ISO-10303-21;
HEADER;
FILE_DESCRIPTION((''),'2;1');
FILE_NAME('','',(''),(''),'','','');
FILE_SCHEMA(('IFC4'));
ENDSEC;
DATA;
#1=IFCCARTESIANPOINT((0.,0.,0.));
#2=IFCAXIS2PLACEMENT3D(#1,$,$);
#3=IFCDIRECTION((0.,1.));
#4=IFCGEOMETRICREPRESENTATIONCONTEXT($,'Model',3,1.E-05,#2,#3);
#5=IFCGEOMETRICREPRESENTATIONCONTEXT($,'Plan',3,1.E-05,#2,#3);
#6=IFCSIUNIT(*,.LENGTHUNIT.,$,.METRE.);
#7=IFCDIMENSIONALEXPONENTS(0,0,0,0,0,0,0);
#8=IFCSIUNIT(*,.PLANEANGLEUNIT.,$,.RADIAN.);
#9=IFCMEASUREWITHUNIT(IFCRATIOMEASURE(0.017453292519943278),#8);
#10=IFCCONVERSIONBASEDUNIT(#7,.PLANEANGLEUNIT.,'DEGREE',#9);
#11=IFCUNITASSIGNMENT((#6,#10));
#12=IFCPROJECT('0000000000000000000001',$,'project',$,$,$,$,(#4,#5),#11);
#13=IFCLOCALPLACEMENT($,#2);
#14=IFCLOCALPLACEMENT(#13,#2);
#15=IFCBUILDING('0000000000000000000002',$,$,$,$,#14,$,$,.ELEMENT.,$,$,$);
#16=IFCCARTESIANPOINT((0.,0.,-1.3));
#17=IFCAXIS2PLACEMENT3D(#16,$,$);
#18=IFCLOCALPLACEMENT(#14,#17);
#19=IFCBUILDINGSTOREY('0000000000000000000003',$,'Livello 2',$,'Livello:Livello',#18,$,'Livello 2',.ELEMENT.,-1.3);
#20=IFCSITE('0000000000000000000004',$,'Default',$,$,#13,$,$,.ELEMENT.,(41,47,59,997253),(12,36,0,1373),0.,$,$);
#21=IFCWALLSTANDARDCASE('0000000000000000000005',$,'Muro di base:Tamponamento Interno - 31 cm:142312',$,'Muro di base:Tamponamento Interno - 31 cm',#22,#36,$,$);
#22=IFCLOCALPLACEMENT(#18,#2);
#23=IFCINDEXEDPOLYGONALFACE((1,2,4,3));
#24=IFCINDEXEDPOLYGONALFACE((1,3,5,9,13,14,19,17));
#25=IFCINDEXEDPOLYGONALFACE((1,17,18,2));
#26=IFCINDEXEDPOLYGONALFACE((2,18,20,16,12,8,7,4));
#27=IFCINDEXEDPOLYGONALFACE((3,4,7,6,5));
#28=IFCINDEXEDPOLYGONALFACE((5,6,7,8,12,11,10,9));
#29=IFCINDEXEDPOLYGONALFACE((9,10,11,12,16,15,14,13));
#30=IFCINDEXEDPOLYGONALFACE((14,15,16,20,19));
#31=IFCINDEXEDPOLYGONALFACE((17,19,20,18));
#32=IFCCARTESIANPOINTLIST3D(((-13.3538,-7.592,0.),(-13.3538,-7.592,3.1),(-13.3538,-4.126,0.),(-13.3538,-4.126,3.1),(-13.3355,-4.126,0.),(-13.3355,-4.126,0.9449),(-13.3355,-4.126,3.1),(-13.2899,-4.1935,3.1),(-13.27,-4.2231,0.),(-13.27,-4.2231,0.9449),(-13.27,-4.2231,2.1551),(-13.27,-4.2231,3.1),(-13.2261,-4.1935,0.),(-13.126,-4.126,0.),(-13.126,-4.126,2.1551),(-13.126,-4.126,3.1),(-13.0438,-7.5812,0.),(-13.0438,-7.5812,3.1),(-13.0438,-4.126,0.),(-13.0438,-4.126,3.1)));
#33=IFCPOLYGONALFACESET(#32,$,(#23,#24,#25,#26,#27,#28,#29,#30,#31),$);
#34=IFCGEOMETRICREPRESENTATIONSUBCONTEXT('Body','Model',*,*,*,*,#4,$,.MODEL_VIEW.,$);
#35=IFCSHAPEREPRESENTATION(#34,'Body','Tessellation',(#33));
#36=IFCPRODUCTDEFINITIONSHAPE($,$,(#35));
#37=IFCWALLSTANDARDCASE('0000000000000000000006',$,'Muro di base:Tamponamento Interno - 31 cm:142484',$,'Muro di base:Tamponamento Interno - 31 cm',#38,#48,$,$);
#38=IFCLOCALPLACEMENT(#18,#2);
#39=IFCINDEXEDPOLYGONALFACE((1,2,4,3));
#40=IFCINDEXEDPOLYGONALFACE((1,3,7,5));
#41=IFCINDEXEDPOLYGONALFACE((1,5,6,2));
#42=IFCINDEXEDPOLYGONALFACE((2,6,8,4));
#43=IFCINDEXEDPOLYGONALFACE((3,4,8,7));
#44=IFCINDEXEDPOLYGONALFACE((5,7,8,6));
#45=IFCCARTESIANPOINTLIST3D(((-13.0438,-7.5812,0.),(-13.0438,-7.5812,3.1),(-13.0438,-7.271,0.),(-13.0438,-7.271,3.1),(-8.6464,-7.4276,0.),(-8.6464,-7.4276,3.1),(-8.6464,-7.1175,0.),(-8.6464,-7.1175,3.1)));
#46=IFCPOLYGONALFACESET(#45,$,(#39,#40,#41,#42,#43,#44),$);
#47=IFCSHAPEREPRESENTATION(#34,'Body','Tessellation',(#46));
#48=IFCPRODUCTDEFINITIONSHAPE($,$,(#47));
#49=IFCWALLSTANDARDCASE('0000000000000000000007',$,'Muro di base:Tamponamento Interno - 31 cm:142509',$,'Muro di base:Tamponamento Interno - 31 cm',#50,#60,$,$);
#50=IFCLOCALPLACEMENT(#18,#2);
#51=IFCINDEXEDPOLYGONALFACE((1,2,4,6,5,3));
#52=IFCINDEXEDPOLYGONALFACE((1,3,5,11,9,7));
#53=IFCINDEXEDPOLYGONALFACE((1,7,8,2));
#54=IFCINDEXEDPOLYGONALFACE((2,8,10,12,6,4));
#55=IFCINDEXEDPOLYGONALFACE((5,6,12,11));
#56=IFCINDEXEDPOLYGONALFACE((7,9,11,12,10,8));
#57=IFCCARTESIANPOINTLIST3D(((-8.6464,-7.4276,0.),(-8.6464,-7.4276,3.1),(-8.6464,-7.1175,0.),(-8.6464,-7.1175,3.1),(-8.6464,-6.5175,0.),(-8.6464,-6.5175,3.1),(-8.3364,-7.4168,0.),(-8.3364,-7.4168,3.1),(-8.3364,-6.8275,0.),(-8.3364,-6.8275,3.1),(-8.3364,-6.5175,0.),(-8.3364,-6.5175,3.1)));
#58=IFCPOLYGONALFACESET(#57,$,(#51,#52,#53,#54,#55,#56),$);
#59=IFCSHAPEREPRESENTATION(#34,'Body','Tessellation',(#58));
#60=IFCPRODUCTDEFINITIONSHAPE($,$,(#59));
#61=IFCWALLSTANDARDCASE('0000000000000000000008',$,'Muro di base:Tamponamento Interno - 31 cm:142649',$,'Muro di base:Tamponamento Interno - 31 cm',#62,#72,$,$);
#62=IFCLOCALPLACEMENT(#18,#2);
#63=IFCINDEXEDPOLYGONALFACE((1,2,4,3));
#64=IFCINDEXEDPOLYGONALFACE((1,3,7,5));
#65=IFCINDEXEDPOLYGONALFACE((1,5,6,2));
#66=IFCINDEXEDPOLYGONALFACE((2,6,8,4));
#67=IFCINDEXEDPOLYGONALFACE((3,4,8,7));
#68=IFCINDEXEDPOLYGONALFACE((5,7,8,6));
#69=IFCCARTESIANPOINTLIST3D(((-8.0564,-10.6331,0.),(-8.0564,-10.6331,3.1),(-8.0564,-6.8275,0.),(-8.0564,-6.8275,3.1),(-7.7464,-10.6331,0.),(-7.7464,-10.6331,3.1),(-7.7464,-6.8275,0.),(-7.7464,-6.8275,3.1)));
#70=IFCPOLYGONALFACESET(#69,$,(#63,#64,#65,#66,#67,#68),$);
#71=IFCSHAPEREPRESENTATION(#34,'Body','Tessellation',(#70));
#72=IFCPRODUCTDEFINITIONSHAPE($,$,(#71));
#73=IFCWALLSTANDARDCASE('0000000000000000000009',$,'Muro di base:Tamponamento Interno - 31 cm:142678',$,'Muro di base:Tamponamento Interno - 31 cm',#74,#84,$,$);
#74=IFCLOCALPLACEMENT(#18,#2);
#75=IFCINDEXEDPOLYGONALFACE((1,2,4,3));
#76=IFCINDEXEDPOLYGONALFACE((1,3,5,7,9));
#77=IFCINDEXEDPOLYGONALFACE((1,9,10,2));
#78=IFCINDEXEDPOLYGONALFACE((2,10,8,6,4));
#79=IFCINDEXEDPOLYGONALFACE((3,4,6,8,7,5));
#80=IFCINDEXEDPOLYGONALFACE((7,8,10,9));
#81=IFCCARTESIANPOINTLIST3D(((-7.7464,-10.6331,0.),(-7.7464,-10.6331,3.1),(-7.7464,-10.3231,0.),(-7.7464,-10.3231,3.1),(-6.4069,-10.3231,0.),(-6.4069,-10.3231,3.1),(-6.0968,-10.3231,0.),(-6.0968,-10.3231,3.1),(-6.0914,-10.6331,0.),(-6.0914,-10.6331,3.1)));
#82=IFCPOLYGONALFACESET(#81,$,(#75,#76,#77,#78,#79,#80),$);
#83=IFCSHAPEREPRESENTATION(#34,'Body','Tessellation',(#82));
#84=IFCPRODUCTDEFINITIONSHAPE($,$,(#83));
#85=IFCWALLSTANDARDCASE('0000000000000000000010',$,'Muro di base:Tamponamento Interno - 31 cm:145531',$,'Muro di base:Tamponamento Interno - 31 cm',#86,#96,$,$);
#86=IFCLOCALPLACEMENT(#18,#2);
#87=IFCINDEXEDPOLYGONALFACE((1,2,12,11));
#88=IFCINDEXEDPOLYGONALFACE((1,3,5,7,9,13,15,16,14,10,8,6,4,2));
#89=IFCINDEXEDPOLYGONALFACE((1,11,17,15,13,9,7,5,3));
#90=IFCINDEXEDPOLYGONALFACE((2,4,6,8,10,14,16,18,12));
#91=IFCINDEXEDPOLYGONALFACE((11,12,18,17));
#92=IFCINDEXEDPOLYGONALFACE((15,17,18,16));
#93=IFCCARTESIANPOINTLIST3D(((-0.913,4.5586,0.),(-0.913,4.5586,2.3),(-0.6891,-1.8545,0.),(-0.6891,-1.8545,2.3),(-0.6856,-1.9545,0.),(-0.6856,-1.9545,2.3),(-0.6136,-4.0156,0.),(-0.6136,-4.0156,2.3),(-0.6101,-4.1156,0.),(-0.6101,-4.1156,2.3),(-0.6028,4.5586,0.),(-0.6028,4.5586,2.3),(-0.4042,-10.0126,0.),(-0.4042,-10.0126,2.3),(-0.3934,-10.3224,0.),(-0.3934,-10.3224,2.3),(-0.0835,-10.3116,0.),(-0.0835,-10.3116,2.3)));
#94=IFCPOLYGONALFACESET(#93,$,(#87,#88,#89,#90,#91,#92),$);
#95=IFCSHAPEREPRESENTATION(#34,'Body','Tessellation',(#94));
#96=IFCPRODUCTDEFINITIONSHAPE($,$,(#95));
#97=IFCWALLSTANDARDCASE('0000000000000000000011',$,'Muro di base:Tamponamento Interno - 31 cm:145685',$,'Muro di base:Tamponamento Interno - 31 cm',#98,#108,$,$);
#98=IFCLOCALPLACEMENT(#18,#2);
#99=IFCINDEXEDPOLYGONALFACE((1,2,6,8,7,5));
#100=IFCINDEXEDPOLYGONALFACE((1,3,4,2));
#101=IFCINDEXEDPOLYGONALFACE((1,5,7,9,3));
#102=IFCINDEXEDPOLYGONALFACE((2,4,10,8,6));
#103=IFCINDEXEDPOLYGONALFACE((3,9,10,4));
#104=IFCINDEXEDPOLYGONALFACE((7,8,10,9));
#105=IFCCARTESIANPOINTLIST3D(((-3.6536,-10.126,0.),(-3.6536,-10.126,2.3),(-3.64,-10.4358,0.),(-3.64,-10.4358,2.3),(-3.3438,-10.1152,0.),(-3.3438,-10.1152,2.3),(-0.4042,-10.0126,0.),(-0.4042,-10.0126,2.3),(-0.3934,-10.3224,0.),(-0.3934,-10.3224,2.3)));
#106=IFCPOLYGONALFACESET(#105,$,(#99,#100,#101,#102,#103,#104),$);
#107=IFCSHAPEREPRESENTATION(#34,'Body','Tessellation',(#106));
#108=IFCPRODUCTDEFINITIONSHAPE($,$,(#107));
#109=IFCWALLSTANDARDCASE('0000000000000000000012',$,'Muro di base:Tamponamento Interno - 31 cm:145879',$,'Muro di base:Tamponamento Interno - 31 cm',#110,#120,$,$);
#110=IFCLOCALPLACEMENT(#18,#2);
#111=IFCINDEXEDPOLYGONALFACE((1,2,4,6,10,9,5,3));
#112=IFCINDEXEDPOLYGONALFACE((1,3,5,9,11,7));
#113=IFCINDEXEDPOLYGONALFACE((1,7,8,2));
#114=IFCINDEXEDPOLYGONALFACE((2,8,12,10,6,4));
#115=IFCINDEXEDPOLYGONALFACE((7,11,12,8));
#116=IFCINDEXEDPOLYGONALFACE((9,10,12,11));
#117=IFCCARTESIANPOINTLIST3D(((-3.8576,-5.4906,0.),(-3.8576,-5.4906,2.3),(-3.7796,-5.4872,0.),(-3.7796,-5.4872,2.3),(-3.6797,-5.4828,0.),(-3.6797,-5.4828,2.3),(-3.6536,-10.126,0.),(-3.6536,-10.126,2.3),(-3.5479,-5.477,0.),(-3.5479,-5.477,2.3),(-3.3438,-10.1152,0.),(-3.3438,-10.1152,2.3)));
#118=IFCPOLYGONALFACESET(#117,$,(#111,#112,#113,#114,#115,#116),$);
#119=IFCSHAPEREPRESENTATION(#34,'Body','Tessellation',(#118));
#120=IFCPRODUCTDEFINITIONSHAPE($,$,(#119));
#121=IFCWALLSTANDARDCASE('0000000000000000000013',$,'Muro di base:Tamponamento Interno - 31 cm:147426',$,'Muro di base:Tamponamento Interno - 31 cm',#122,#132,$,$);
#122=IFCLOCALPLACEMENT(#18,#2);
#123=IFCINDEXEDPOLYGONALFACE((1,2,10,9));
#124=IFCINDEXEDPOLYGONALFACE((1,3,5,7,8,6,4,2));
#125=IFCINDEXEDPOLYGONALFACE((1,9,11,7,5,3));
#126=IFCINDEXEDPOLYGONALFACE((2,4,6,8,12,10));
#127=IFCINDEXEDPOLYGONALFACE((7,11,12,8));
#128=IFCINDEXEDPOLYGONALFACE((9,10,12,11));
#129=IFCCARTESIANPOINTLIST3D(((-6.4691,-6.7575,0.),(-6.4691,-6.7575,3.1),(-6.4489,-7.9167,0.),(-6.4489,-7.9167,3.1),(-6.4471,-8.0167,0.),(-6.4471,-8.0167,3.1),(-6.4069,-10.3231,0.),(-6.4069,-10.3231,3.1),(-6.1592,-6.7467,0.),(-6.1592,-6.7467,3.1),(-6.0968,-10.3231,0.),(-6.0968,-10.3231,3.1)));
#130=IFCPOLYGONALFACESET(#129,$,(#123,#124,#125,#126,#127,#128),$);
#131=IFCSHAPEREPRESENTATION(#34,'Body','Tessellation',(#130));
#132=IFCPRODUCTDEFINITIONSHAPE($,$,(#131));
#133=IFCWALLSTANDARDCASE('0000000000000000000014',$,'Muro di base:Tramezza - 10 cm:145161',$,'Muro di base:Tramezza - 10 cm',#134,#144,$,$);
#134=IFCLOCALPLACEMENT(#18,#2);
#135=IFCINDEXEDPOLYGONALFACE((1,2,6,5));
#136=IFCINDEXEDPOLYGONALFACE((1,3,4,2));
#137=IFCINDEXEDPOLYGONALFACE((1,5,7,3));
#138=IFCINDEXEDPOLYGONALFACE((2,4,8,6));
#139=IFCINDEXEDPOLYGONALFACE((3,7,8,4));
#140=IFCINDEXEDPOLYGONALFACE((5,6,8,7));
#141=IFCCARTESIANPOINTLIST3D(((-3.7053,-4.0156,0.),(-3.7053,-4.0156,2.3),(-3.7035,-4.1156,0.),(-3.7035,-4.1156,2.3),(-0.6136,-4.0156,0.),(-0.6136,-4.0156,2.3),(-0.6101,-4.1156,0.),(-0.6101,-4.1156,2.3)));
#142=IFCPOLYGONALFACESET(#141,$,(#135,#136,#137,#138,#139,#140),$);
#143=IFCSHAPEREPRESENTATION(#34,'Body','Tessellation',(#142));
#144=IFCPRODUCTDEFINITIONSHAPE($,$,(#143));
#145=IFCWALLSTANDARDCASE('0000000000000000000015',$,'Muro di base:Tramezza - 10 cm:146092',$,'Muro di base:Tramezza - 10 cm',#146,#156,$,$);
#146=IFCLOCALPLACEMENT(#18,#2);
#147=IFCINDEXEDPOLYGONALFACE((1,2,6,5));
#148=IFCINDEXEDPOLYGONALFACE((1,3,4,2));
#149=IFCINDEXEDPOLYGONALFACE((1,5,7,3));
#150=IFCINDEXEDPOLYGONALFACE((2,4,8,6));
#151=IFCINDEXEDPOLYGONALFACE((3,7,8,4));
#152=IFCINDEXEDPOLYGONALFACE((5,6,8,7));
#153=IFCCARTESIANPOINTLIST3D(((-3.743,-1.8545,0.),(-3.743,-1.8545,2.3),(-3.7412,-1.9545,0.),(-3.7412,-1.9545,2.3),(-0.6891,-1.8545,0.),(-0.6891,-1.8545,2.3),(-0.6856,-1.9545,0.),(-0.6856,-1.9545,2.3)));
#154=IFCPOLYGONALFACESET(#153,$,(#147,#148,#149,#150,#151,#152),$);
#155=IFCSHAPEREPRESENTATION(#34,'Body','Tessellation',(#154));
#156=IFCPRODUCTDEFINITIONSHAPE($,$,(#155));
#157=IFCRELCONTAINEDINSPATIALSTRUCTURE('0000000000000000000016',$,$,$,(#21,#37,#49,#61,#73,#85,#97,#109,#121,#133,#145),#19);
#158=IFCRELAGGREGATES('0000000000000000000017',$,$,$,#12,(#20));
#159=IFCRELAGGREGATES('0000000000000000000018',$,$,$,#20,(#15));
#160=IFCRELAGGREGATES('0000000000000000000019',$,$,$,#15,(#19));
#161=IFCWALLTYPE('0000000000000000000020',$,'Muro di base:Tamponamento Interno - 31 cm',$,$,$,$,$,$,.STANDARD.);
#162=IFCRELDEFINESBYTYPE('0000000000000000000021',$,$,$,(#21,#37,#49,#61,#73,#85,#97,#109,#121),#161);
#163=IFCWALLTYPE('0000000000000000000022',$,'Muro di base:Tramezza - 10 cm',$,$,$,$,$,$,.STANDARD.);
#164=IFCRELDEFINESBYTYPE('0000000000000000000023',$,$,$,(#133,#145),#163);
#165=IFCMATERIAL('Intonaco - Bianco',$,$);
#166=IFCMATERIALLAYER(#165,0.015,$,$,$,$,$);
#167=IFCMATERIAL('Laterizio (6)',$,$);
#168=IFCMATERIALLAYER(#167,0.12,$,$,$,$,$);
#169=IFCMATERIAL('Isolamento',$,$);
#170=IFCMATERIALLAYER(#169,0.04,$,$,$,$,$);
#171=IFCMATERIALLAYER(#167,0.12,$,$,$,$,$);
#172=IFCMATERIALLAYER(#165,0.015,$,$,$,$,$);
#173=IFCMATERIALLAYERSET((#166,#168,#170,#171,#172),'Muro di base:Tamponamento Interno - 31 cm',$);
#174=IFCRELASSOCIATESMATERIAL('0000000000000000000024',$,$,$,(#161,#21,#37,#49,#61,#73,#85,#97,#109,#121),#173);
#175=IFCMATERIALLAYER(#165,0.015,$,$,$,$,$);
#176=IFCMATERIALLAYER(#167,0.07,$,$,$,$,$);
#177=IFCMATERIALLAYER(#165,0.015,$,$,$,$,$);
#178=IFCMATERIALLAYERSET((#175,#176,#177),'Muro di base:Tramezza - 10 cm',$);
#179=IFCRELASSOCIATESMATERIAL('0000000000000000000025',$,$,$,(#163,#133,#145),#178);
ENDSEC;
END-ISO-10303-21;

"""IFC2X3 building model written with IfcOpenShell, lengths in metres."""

from ifc_helpers import new_model, entity, si_unit, converted_unit, direction, frame, frame_2d, origin, place, context, subcontext, project, spatial, polyline, rectangle, outline, extrude, clip, bounded_halfspace, material, layer, layer_set, layer_usage, type_object, element, save


model = new_model("IFC2X3")

# Units and contexts
model_context = context("Model", 3, precision=1e-05, world=origin(), true_north=direction((0.0, 1.0)))
plan_context = context("Plan", 3, precision=1e-05, world=origin(), true_north=direction((0.0, 1.0)))
body_context = subcontext(model_context, "Body", "Model", "MODEL_VIEW")
ifc_project = project(units=[si_unit("LENGTHUNIT", "METRE"), converted_unit("PLANEANGLEUNIT", "DEGREE", entity("IfcRatioMeasure", 0.017453292519943278), si_unit("PLANEANGLEUNIT", "RADIAN"), dimensions=[0, 0, 0, 0, 0, 0, 0])], contexts=[model_context, plan_context])

# Site, building, storey
site_placement = place(None, origin())
site = spatial("IfcSite", under=ifc_project, at=site_placement, Name="Default", CompositionType="ELEMENT", RefLatitude=(41, 47, 59, 997253), RefLongitude=(12, 36, 0, 1373), RefElevation=0.0)
building_placement = place(site_placement, origin())
building = spatial("IfcBuilding", under=site, at=building_placement, CompositionType="ELEMENT")
storey_placement = place(building_placement, frame((0.0, 0.0, -1.3)))
storey = spatial("IfcBuildingStorey", under=building, at=storey_placement, Name="Livello 2", ObjectType="Livello:Livello", LongName="Livello 2", CompositionType="ELEMENT", Elevation=-1.3)

# Shared definitions
ifc_material_1 = material(Name="Intonaco - Bianco")

# Shared definitions
ifc_layer_1 = layer(ifc_material_1, 0.015)
ifc_material_2 = material(Name="Laterizio (6)")
ifc_layer_2 = layer(ifc_material_2, 0.12)
ifc_material_3 = material(Name="Isolamento")
ifc_layer_3 = layer(ifc_material_3, 0.04)
ifc_layer_4 = layer(ifc_material_2, 0.12)
ifc_layer_5 = layer(ifc_material_1, 0.015)
ifc_layer_set_1 = layer_set([ifc_layer_1, ifc_layer_2, ifc_layer_3, ifc_layer_4, ifc_layer_5], Name="Muro di base:Tamponamento Interno - 31 cm")
wall_type_1 = type_object("IfcWallType", Name="Muro di base:Tamponamento Interno - 31 cm", PredefinedType="STANDARD", material=ifc_layer_set_1)

# Walls
ifc_layer_usage_1 = layer_usage(ifc_layer_set_1, "AXIS2", "NEGATIVE", 0.155)
wall_1_placement = place(storey_placement, frame((-13.1988, -4.126, 0.0), z_axis=(0.0, 0.0, 1.0), x_axis=(0.0, -1.0, 0.0)))
element("IfcWallStandardCase", 1, at=wall_1_placement, inside=storey, type_object=wall_type_1, material=ifc_layer_usage_1, Name="Muro di base:Tamponamento Interno - 31 cm:142312", ObjectType="Muro di base:Tamponamento Interno - 31 cm", context=body_context, shape_type="Clipping", body=[
    clip(clip(extrude(outline(polyline([(3.466, -0.155), (3.4552, 0.155), (3.145, 0.155), (0.0, 0.155), (0.0, 0.0728), (0.0971, -0.0712), (0.0, -0.1367), (0.0, -0.155), (3.466, -0.155)])), origin(), (0.0, 0.0, 1.0), 3.1), bounded_halfspace(frame((0.0971, -0.0712, 3.1), z_axis=(0.559193, -0.829038, 0.0), x_axis=(0.0, 0.0, -1.0)), True, frame((0.0971, -0.0712, 3.1), z_axis=(0.559193, -0.829038, 0.0), x_axis=(0.0, 0.0, -1.0)), polyline([(0.0, 0.0), (0.0, -0.0357), (0.9449, -0.0357), (0.9449, 0.0), (0.0, 0.0)]))), bounded_halfspace(frame((0.0971, -0.0712, 0.0), z_axis=(0.829038, 0.559193, 0.0), x_axis=(0.0, 0.0, -1.0)), True, frame((0.0971, -0.0712, 0.0), z_axis=(0.829038, 0.559193, 0.0), x_axis=(0.0, 0.0, -1.0)), polyline([(0.0, 0.0), (0.0, 0.0529), (-0.9449, 0.0529), (-0.9449, 0.0), (0.0, 0.0)]))),
])
ifc_layer_usage_2 = layer_usage(ifc_layer_set_1, "AXIS2", "NEGATIVE", 0.155)
wall_2_placement = place(storey_placement, frame((-13.0492, -7.4263, 0.0), z_axis=(0.0, 0.0, 1.0), x_axis=(0.999391, 0.034899, 0.0)))
element("IfcWallStandardCase", 2, at=wall_2_placement, inside=storey, type_object=wall_type_1, material=ifc_layer_usage_2, Name="Muro di base:Tamponamento Interno - 31 cm:142484", ObjectType="Muro di base:Tamponamento Interno - 31 cm", context=body_context, shape_type="SweptSolid", body=[
    extrude(outline(polyline([(4.4, -0.155), (4.4108, 0.155), (0.0108, 0.155), (0.0, -0.155), (4.4, -0.155)])), origin(), (0.0, 0.0, 1.0), 3.1),
])
ifc_layer_usage_3 = layer_usage(ifc_layer_set_1, "AXIS2", "NEGATIVE", 0.155)
wall_3_placement = place(storey_placement, frame((-8.4914, -7.4276, 0.0), z_axis=(0.0, 0.0, 1.0), x_axis=(0.0, 1.0, 0.0)))
element("IfcWallStandardCase", 3, at=wall_3_placement, inside=storey, type_object=wall_type_1, material=ifc_layer_usage_3, Name="Muro di base:Tamponamento Interno - 31 cm:142509", ObjectType="Muro di base:Tamponamento Interno - 31 cm", context=body_context, shape_type="SweptSolid", body=[
    extrude(outline(polyline([(0.9102, -0.155), (0.9102, 0.155), (0.3102, 0.155), (0.0, 0.155), (0.0108, -0.155), (0.6002, -0.155), (0.9102, -0.155)])), origin(), (0.0, 0.0, 1.0), 3.1),
])
ifc_layer_usage_4 = layer_usage(ifc_layer_set_1, "AXIS2", "NEGATIVE", 0.155)
wall_4_placement = place(storey_placement, frame((-7.9014, -6.8275, 0.0), z_axis=(0.0, 0.0, 1.0), x_axis=(0.0, -1.0, 0.0)))
element("IfcWallStandardCase", 4, at=wall_4_placement, inside=storey, type_object=wall_type_1, material=ifc_layer_usage_4, Name="Muro di base:Tamponamento Interno - 31 cm:142649", ObjectType="Muro di base:Tamponamento Interno - 31 cm", context=body_context, shape_type="SweptSolid", body=[
    extrude(rectangle(XDim=3.8056, YDim=0.31, at=frame_2d((1.9028, 0.0), x_axis=(-1.0, 0.0))), origin(), (0.0, 0.0, 1.0), 3.1),
])
ifc_layer_usage_5 = layer_usage(ifc_layer_set_1, "AXIS2", "NEGATIVE", 0.155)
wall_5_placement = place(storey_placement, frame((-7.7464, -10.4781, 0.0)))
element("IfcWallStandardCase", 5, at=wall_5_placement, inside=storey, type_object=wall_type_1, material=ifc_layer_usage_5, Name="Muro di base:Tamponamento Interno - 31 cm:142678", ObjectType="Muro di base:Tamponamento Interno - 31 cm", context=body_context, shape_type="SweptSolid", body=[
    extrude(outline(polyline([(1.655, -0.155), (1.6496, 0.155), (1.3396, 0.155), (0.0, 0.155), (0.0, -0.155), (1.655, -0.155)])), origin(), (0.0, 0.0, 1.0), 3.1),
])
ifc_layer_usage_6 = layer_usage(ifc_layer_set_1, "AXIS2", "POSITIVE", -0.155)
wall_6_placement = place(storey_placement, frame((-0.7581, 4.564, 0.0), z_axis=(0.0, 0.0, 1.0), x_axis=(0.034899, -0.999391, 0.0)))
element("IfcWallStandardCase", 6, at=wall_6_placement, inside=storey, type_object=wall_type_1, material=ifc_layer_usage_6, Name="Muro di base:Tamponamento Interno - 31 cm:145531", ObjectType="Muro di base:Tamponamento Interno - 31 cm", context=body_context, shape_type="SweptSolid", body=[
    extrude(outline(polyline([(14.89, -0.155), (14.89, 0.155), (0.0108, 0.155), (0.0, -0.155), (6.4169, -0.155), (6.517, -0.155), (8.5794, -0.155), (8.6794, -0.155), (14.58, -0.155), (14.89, -0.155)])), origin(), (0.0, 0.0, 1.0), 2.3),
])
ifc_layer_usage_7 = layer_usage(ifc_layer_set_1, "AXIS2", "POSITIVE", -0.155)
wall_7_placement = place(storey_placement, frame((-0.3988, -10.1675, 0.0), z_axis=(0.0, 0.0, 1.0), x_axis=(-0.999391, -0.034899, 0.0)))
element("IfcWallStandardCase", 7, at=wall_7_placement, inside=storey, type_object=wall_type_1, material=ifc_layer_usage_7, Name="Muro di base:Tamponamento Interno - 31 cm:145685", ObjectType="Muro di base:Tamponamento Interno - 31 cm", context=body_context, shape_type="SweptSolid", body=[
    extrude(outline(polyline([(3.2514, -0.155), (3.2486, 0.155), (0.0, 0.155), (0.0, -0.155), (2.9414, -0.155), (3.2514, -0.155)])), origin(), (0.0, 0.0, 1.0), 2.3),
])
ifc_layer_usage_8 = layer_usage(ifc_layer_set_1, "AXIS2", "POSITIVE", -0.155)
wall_8_placement = place(storey_placement, frame((-3.4987, -10.122, 0.0), z_axis=(0.0, 0.0, 1.0), x_axis=(-0.043964, 0.999033, 0.0)))
element("IfcWallStandardCase", 8, at=wall_8_placement, inside=storey, type_object=wall_type_1, material=ifc_layer_usage_8, Name="Muro di base:Tamponamento Interno - 31 cm:145879", ObjectType="Muro di base:Tamponamento Interno - 31 cm", context=body_context, shape_type="SweptSolid", body=[
    extrude(outline(polyline([(4.6427, -0.155), (4.6427, -0.0231), (4.6427, 0.0769), (4.6427, 0.155), (0.0028, 0.155), (0.0, -0.155), (4.6427, -0.155)])), origin(), (0.0, 0.0, 1.0), 2.3),
])
ifc_layer_usage_9 = layer_usage(ifc_layer_set_1, "AXIS2", "NEGATIVE", 0.155)
wall_9_placement = place(storey_placement, frame((-6.2518, -10.3258, 0.0), z_axis=(0.0, 0.0, 1.0), x_axis=(-0.017452, 0.999848, 0.0)))
element("IfcWallStandardCase", 9, at=wall_9_placement, inside=storey, type_object=wall_type_1, material=ifc_layer_usage_9, Name="Muro di base:Tamponamento Interno - 31 cm:147426", ObjectType="Muro di base:Tamponamento Interno - 31 cm", context=body_context, shape_type="SweptSolid", body=[
    extrude(outline(polyline([(3.5769, -0.155), (3.5715, 0.155), (2.4121, 0.155), (2.3121, 0.155), (0.0054, 0.155), (0.0, -0.155), (3.5769, -0.155)])), origin(), (0.0, 0.0, 1.0), 3.1),
])
ifc_layer_6 = layer(ifc_material_1, 0.015)
ifc_layer_7 = layer(ifc_material_2, 0.07)
ifc_layer_8 = layer(ifc_material_1, 0.015)
ifc_layer_set_2 = layer_set([ifc_layer_6, ifc_layer_7, ifc_layer_8], Name="Muro di base:Tramezza - 10 cm")
ifc_layer_usage_10 = layer_usage(ifc_layer_set_2, "AXIS2", "NEGATIVE", 0.05)
wall_type_2 = type_object("IfcWallType", Name="Muro di base:Tramezza - 10 cm", PredefinedType="STANDARD", material=ifc_layer_set_2)
wall_10_placement = place(storey_placement, frame((-3.7053, -4.0656, 0.0)))
element("IfcWallStandardCase", 10, at=wall_10_placement, inside=storey, type_object=wall_type_2, material=ifc_layer_usage_10, Name="Muro di base:Tramezza - 10 cm:145161", ObjectType="Muro di base:Tramezza - 10 cm", context=body_context, shape_type="SweptSolid", body=[
    extrude(outline(polyline([(3.0952, -0.05), (3.0917, 0.05), (0.0, 0.05), (0.0017, -0.05), (3.0952, -0.05)])), origin(), (0.0, 0.0, 1.0), 2.3),
])
ifc_layer_usage_11 = layer_usage(ifc_layer_set_2, "AXIS2", "POSITIVE", -0.05)
wall_11_placement = place(storey_placement, frame((-0.6856, -1.9045, 0.0), z_axis=(0.0, 0.0, 1.0), x_axis=(-1.0, 0.0, 0.0)))
element("IfcWallStandardCase", 11, at=wall_11_placement, inside=storey, type_object=wall_type_2, material=ifc_layer_usage_11, Name="Muro di base:Tramezza - 10 cm:146092", ObjectType="Muro di base:Tramezza - 10 cm", context=body_context, shape_type="SweptSolid", body=[
    extrude(outline(polyline([(3.0574, -0.05), (3.0557, 0.05), (0.0, 0.05), (0.0035, -0.05), (3.0574, -0.05)])), origin(), (0.0, 0.0, 1.0), 2.3),
])

save(model, "model.ifc")
